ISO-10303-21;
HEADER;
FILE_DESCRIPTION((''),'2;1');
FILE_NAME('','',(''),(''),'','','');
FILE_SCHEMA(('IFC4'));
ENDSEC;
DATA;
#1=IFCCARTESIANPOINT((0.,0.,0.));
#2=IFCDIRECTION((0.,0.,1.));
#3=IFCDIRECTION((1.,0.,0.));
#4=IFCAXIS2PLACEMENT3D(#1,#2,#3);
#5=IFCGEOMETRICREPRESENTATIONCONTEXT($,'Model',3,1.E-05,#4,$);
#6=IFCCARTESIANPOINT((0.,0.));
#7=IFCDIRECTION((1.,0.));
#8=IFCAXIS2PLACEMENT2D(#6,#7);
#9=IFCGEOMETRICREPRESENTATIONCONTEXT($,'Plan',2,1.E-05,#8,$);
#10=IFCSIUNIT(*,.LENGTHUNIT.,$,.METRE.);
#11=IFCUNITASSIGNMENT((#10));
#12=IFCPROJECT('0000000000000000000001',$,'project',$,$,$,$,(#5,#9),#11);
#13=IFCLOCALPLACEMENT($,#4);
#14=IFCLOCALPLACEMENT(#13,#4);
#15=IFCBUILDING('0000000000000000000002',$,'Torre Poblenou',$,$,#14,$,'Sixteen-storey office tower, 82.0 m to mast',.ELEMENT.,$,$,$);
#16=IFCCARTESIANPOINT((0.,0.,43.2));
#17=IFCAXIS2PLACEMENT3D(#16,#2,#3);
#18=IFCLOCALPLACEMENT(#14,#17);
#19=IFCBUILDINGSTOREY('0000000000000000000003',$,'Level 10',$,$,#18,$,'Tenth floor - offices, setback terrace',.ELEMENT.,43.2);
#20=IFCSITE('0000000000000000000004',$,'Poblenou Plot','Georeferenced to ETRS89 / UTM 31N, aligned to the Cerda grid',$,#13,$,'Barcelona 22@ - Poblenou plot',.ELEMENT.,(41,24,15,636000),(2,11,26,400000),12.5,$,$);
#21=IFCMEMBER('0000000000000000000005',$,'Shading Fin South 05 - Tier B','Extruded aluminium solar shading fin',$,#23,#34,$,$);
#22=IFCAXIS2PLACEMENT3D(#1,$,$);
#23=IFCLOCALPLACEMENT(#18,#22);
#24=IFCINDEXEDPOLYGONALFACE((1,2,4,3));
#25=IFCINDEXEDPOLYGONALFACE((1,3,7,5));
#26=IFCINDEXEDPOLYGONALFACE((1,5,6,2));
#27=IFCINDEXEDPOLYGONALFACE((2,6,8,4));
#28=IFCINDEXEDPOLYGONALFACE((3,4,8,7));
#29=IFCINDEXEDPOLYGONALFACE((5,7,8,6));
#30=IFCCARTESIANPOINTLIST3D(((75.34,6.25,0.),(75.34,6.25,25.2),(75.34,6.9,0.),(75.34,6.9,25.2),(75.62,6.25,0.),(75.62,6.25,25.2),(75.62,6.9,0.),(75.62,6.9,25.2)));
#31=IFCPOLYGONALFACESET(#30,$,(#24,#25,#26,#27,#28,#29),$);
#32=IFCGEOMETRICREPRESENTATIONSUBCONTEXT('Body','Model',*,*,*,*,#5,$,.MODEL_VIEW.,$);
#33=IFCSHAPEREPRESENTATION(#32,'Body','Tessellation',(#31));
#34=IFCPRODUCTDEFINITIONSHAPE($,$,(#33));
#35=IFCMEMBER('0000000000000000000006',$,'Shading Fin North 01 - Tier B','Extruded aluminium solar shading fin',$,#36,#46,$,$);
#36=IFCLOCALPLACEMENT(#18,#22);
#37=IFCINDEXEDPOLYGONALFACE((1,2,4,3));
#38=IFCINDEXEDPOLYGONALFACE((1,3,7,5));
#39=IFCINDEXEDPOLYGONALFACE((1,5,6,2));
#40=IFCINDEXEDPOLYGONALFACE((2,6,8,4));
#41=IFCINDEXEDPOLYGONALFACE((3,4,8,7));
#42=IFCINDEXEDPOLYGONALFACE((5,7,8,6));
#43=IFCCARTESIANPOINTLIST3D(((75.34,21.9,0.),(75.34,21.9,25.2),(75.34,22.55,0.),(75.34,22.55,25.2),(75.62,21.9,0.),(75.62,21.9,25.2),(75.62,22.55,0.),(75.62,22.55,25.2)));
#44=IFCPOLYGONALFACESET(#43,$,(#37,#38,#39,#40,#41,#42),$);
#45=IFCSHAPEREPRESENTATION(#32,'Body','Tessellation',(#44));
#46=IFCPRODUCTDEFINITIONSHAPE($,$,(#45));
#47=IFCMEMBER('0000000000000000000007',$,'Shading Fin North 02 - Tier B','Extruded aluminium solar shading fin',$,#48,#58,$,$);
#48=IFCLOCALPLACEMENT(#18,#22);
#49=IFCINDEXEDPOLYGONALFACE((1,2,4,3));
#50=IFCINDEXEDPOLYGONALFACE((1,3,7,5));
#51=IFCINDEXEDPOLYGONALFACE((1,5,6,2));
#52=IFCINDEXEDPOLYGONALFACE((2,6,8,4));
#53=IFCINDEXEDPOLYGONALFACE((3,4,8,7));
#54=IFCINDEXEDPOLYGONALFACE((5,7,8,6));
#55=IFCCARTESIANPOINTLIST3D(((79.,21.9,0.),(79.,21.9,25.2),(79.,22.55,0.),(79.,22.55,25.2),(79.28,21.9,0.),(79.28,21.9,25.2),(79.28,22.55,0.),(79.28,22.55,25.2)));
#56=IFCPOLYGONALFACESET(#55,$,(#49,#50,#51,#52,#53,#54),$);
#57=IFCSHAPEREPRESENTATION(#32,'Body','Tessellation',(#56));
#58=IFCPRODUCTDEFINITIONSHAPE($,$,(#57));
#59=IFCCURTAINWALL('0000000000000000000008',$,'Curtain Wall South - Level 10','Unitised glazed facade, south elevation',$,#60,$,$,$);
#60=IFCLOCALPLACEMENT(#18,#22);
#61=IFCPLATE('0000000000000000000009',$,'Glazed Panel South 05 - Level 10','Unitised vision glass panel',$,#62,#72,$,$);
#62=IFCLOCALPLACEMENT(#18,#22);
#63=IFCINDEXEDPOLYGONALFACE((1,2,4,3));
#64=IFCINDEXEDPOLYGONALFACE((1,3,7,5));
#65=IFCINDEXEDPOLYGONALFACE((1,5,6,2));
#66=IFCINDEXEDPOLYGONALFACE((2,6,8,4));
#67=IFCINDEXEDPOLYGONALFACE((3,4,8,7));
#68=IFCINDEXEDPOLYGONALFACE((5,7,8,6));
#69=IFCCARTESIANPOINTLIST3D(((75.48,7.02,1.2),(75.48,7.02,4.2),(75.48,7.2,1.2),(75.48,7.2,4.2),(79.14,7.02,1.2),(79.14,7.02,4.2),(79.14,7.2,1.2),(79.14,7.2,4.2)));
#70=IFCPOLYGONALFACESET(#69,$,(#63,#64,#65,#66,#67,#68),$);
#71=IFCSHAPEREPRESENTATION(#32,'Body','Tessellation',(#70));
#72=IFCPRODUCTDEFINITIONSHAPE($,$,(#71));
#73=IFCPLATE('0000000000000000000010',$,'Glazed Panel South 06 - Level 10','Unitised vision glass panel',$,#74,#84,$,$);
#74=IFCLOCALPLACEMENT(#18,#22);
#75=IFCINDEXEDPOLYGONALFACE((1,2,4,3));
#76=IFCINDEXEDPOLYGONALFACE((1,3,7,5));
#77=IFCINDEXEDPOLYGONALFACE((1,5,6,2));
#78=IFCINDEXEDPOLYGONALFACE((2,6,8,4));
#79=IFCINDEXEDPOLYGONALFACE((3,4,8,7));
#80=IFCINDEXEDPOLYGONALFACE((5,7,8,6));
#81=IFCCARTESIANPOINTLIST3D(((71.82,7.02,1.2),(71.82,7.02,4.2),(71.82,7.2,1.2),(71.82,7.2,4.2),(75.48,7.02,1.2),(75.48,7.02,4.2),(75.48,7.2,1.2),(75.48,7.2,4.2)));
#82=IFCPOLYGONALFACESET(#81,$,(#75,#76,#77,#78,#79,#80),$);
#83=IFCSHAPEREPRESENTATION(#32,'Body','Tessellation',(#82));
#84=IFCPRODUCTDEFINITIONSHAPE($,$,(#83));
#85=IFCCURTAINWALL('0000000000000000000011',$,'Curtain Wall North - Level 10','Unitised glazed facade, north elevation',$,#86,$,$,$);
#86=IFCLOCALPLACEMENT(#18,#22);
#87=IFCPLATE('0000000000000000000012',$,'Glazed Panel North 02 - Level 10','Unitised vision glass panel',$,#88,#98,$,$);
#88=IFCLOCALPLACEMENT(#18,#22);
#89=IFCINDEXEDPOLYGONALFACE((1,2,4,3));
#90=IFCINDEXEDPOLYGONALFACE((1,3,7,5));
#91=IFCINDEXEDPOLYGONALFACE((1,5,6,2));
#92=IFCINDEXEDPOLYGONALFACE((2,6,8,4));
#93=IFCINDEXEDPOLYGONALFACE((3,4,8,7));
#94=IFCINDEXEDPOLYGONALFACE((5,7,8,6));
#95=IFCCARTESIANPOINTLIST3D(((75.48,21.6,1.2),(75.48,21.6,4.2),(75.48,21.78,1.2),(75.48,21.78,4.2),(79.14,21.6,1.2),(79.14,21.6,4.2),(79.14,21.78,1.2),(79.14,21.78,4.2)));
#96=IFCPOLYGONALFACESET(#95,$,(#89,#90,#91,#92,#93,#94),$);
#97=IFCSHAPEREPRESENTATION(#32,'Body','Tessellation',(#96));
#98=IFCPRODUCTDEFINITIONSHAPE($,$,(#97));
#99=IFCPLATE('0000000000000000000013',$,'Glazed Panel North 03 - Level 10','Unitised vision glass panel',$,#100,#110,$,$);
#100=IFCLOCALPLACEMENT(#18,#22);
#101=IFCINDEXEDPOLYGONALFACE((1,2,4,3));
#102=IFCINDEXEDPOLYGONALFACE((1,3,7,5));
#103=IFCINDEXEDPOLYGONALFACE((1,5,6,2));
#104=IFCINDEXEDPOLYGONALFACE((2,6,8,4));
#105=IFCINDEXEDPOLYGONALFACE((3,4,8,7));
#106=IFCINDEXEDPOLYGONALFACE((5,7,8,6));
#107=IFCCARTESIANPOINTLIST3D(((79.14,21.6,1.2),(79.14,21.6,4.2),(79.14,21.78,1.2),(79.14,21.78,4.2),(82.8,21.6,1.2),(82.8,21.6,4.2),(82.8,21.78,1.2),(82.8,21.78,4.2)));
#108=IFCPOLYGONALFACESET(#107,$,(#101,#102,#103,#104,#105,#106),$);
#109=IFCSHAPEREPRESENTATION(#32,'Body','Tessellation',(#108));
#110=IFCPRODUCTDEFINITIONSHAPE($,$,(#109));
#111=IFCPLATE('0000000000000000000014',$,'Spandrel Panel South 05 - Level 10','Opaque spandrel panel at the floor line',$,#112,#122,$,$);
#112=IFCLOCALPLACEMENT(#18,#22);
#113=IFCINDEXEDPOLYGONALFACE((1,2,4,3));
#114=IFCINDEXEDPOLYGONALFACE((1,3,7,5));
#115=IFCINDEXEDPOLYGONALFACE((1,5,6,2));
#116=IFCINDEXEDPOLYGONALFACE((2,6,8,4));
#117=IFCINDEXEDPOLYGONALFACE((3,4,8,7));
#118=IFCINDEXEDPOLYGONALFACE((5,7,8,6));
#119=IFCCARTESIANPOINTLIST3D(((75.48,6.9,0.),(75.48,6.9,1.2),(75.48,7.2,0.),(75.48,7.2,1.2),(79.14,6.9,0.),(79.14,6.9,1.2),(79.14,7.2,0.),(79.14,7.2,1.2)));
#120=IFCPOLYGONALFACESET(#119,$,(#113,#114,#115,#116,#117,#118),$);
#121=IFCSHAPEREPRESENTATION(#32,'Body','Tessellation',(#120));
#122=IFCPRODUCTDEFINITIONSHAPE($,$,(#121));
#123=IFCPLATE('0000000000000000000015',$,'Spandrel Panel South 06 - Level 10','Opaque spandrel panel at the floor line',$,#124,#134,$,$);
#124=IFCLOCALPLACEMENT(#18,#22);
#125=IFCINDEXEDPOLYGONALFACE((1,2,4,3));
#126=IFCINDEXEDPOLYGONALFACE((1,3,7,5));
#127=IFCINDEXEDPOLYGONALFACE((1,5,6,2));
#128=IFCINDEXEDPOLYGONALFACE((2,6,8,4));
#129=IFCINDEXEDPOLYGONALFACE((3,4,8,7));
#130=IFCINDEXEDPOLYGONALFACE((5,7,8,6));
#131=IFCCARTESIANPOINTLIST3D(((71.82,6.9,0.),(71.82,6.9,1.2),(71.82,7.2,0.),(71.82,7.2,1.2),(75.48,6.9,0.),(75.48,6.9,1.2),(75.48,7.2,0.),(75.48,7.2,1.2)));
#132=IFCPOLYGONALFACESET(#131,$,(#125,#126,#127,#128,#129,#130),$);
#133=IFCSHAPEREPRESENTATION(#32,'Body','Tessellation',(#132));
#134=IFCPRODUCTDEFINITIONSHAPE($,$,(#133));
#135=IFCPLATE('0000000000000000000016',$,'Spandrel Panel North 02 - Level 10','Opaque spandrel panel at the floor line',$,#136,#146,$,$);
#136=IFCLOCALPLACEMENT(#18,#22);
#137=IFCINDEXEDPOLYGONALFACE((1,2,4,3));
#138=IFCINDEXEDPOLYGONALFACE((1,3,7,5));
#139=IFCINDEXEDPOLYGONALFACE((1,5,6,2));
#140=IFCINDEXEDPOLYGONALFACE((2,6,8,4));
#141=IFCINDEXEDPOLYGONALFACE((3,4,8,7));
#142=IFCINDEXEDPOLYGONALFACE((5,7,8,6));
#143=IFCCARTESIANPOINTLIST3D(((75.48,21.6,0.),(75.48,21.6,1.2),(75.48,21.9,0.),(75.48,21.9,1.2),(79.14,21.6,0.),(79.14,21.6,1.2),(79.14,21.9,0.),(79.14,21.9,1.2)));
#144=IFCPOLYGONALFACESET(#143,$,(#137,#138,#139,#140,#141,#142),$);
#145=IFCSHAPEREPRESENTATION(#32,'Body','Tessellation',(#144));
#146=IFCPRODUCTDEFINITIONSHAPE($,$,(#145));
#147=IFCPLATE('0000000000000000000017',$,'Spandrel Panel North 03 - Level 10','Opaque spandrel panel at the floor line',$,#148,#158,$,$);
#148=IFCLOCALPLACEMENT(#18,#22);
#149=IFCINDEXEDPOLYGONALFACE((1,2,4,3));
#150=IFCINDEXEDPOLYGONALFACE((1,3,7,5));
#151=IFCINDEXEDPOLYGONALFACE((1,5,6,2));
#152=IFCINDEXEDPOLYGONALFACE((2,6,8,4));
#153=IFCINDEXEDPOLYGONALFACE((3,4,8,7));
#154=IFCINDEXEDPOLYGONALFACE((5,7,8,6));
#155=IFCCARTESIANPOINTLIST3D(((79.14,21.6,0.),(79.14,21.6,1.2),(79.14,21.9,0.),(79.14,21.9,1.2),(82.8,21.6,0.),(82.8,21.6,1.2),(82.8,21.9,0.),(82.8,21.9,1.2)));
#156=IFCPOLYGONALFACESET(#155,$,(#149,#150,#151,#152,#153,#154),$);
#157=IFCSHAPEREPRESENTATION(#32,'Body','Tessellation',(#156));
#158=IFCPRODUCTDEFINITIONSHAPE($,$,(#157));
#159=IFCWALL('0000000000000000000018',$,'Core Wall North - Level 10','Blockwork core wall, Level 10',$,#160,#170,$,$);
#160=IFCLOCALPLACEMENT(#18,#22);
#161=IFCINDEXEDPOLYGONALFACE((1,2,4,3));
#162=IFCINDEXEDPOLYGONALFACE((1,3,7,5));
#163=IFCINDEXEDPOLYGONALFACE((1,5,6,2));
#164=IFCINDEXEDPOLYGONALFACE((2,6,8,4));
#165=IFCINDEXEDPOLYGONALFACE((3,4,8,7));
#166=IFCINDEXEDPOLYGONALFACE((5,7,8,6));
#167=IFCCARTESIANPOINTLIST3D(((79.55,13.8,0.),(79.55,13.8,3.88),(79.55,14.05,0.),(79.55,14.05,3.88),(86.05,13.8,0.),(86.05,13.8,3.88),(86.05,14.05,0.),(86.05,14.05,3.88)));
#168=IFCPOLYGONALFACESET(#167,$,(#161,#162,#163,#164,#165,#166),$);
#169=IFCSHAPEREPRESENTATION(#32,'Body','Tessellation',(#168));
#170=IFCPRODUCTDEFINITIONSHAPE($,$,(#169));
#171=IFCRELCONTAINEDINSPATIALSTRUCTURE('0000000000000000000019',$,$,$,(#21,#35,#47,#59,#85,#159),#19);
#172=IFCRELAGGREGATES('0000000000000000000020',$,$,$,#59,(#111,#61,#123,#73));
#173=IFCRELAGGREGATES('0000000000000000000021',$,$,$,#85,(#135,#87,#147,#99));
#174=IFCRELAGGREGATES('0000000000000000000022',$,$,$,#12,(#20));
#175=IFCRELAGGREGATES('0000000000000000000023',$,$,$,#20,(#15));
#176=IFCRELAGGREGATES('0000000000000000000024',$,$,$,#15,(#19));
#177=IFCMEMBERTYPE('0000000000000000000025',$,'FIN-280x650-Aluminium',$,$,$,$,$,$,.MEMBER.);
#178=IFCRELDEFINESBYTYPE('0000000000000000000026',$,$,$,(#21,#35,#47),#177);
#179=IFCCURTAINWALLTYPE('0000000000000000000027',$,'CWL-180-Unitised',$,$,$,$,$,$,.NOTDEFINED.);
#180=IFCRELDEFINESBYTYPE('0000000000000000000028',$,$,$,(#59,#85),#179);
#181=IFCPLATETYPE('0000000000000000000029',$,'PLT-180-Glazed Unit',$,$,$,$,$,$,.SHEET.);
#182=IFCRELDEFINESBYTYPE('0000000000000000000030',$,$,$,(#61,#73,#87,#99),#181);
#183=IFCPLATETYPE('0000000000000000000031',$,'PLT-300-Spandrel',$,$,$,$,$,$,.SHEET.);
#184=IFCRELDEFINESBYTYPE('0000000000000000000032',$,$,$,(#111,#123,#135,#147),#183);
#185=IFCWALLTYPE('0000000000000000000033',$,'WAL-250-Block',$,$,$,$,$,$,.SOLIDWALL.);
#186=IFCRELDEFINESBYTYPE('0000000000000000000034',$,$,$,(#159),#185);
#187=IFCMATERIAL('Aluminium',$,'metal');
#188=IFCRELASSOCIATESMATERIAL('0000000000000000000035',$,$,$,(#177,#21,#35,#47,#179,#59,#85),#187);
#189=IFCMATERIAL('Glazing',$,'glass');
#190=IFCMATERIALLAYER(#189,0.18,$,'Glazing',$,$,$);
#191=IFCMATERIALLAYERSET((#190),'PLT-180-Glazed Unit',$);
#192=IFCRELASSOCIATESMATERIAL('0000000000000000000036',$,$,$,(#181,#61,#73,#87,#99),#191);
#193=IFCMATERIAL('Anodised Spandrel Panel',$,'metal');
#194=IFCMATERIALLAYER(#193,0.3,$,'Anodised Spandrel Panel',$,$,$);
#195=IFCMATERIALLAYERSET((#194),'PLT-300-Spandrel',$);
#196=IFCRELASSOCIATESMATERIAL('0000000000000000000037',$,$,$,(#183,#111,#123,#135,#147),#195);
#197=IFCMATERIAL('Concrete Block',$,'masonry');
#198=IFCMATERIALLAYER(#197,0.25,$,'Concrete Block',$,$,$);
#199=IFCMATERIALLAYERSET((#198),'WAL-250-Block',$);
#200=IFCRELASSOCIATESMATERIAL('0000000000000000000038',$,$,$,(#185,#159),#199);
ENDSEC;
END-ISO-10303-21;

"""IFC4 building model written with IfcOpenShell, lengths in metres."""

from ifc_helpers import new_model, si_unit, frame, origin_with_axes, origin_2d_with_axis, place, context, subcontext, project, spatial, line, indexed_curve, rectangle, outline, extrude, material, layer, layer_set, layer_usage, material_profile, profile_set, profile_usage, type_object, element, aggregate, save


model = new_model("IFC4")

# Units and contexts
model_context = context("Model", 3, precision=1e-05, world=origin_with_axes())
plan_context = context("Plan", 2, precision=1e-05, world=origin_2d_with_axis())
body_context = subcontext(model_context, "Body", "Model", "MODEL_VIEW")
ifc_project = project(units=[si_unit("LENGTHUNIT", "METRE")], contexts=[model_context, plan_context])

# Site, building, storey
site_placement = place(None, origin_with_axes())
site = spatial("IfcSite", under=ifc_project, at=site_placement, Name="Poblenou Plot", Description="Georeferenced to ETRS89 / UTM 31N, aligned to the Cerda grid", LongName="Barcelona 22@ - Poblenou plot", CompositionType="ELEMENT", RefLatitude=(41, 24, 15, 636000), RefLongitude=(2, 11, 26, 400000), RefElevation=12.5)
building_placement = place(site_placement, origin_with_axes())
building = spatial("IfcBuilding", under=site, at=building_placement, Name="Torre Poblenou", LongName="Sixteen-storey office tower, 82.0 m to mast", CompositionType="ELEMENT")
storey_placement = place(building_placement, frame((0.0, 0.0, 43.2), z_axis=(0.0, 0.0, 1.0), x_axis=(1.0, 0.0, 0.0)))
storey = spatial("IfcBuildingStorey", under=building, at=storey_placement, Name="Level 10", LongName="Tenth floor - offices, setback terrace", CompositionType="ELEMENT", Elevation=43.2)

# Members
ifc_material_1 = material(Name="Aluminium", Category="metal")
ifc_material_profile_1 = material_profile(ifc_material_1, rectangle(XDim=0.28, YDim=0.65))
ifc_profile_set_1 = profile_set([ifc_material_profile_1], Name="FIN-280x650-Aluminium")
member_type = type_object("IfcMemberType", Name="FIN-280x650-Aluminium", PredefinedType="MEMBER", material=ifc_profile_set_1)
ifc_profile_usage_1 = profile_usage(ifc_profile_set_1)
member_1_placement = place(storey_placement, frame((75.62, 6.9, 0.0), z_axis=(0.0, 0.0, 1.0), x_axis=(-1.0, 0.0, 0.0)))
element("IfcMember", 1, at=member_1_placement, inside=storey, type_object=member_type, material=ifc_profile_usage_1, Name="Shading Fin South 05 - Tier B", Description="Extruded aluminium solar shading fin", context=body_context, shape_type="SweptSolid", body=[
    extrude(outline(indexed_curve([(0.0, 0.0), (0.28, 0.0), (0.28, 0.65), (0.0, 0.65)], segments=[line(1, 2, 3, 4, 1)])), origin_with_axes(), (0.0, 0.0, 1.0), 25.2),
])
ifc_profile_usage_2 = profile_usage(ifc_profile_set_1)
member_2_placement = place(storey_placement, frame((75.34, 21.9, 0.0), z_axis=(0.0, 0.0, 1.0), x_axis=(1.0, 0.0, 0.0)))
element("IfcMember", 2, at=member_2_placement, inside=storey, type_object=member_type, material=ifc_profile_usage_2, Name="Shading Fin North 01 - Tier B", Description="Extruded aluminium solar shading fin", context=body_context, shape_type="SweptSolid", body=[
    extrude(outline(indexed_curve([(0.0, 0.0), (0.28, 0.0), (0.28, 0.65), (0.0, 0.65)], segments=[line(1, 2, 3, 4, 1)])), origin_with_axes(), (0.0, 0.0, 1.0), 25.2),
])
ifc_profile_usage_3 = profile_usage(ifc_profile_set_1)
member_3_placement = place(storey_placement, frame((79.0, 21.9, 0.0), z_axis=(0.0, 0.0, 1.0), x_axis=(1.0, 0.0, 0.0)))
element("IfcMember", 3, at=member_3_placement, inside=storey, type_object=member_type, material=ifc_profile_usage_3, Name="Shading Fin North 02 - Tier B", Description="Extruded aluminium solar shading fin", context=body_context, shape_type="SweptSolid", body=[
    extrude(outline(indexed_curve([(0.0, 0.0), (0.28, 0.0), (0.28, 0.65), (0.0, 0.65)], segments=[line(1, 2, 3, 4, 1)])), origin_with_axes(), (0.0, 0.0, 1.0), 25.2),
])

# Curtain walls, plates
curtain_wall_type = type_object("IfcCurtainWallType", Name="CWL-180-Unitised", PredefinedType="NOTDEFINED", material=ifc_material_1)
curtain_wall_1_placement = place(storey_placement, frame((93.78, 7.2, 0.0), z_axis=(0.0, 0.0, 1.0), x_axis=(-1.0, 0.0, 0.0)))
curtain_wall_1 = element("IfcCurtainWall", 4, at=curtain_wall_1_placement, inside=storey, type_object=curtain_wall_type, material=ifc_material_1, Name="Curtain Wall South - Level 10", Description="Unitised glazed facade, south elevation")
ifc_material_2 = material(Name="Glazing", Category="glass")
ifc_layer_1 = layer(ifc_material_2, 0.18, Name="Glazing")
ifc_layer_set_1 = layer_set([ifc_layer_1], Name="PLT-180-Glazed Unit")
ifc_layer_usage_1 = layer_usage(ifc_layer_set_1, "AXIS2", "POSITIVE", 0.0)
plate_type_1 = type_object("IfcPlateType", Name="PLT-180-Glazed Unit", PredefinedType="SHEET", material=ifc_layer_set_1)
plate_1_placement = place(curtain_wall_1_placement, frame((14.64, 0.0, 1.2), z_axis=(0.0, 0.0, 1.0), x_axis=(1.0, 0.0, 0.0)))
plate_1 = element("IfcPlate", 5, at=plate_1_placement, type_object=plate_type_1, material=ifc_layer_usage_1, Name="Glazed Panel South 05 - Level 10", Description="Unitised vision glass panel", context=body_context, shape_type="SweptSolid", body=[
    extrude(outline(indexed_curve([(0.0, 0.0), (3.66, 0.0), (3.66, 0.18), (0.0, 0.18)], segments=[line(1, 2, 3, 4, 1)])), origin_with_axes(), (0.0, 0.0, 1.0), 3.0),
])
ifc_layer_usage_2 = layer_usage(ifc_layer_set_1, "AXIS2", "POSITIVE", 0.0)
plate_2_placement = place(curtain_wall_1_placement, frame((18.3, 0.0, 1.2), z_axis=(0.0, 0.0, 1.0), x_axis=(1.0, 0.0, 0.0)))
plate_2 = element("IfcPlate", 6, at=plate_2_placement, type_object=plate_type_1, material=ifc_layer_usage_2, Name="Glazed Panel South 06 - Level 10", Description="Unitised vision glass panel", context=body_context, shape_type="SweptSolid", body=[
    extrude(outline(indexed_curve([(0.0, 0.0), (3.66, 0.0), (3.66, 0.18), (0.0, 0.18)], segments=[line(1, 2, 3, 4, 1)])), origin_with_axes(), (0.0, 0.0, 1.0), 3.0),
])
curtain_wall_2_placement = place(storey_placement, frame((71.82, 21.6, 0.0), z_axis=(0.0, 0.0, 1.0), x_axis=(1.0, 0.0, 0.0)))
curtain_wall_2 = element("IfcCurtainWall", 7, at=curtain_wall_2_placement, inside=storey, type_object=curtain_wall_type, material=ifc_material_1, Name="Curtain Wall North - Level 10", Description="Unitised glazed facade, north elevation")
ifc_layer_usage_3 = layer_usage(ifc_layer_set_1, "AXIS2", "POSITIVE", 0.0)
plate_3_placement = place(curtain_wall_2_placement, frame((3.66, 0.0, 1.2), z_axis=(0.0, 0.0, 1.0), x_axis=(1.0, 0.0, 0.0)))
plate_3 = element("IfcPlate", 8, at=plate_3_placement, type_object=plate_type_1, material=ifc_layer_usage_3, Name="Glazed Panel North 02 - Level 10", Description="Unitised vision glass panel", context=body_context, shape_type="SweptSolid", body=[
    extrude(outline(indexed_curve([(0.0, 0.0), (3.66, 0.0), (3.66, 0.18), (0.0, 0.18)], segments=[line(1, 2, 3, 4, 1)])), origin_with_axes(), (0.0, 0.0, 1.0), 3.0),
])
ifc_layer_usage_4 = layer_usage(ifc_layer_set_1, "AXIS2", "POSITIVE", 0.0)
plate_4_placement = place(curtain_wall_2_placement, frame((7.32, 0.0, 1.2), z_axis=(0.0, 0.0, 1.0), x_axis=(1.0, 0.0, 0.0)))
plate_4 = element("IfcPlate", 9, at=plate_4_placement, type_object=plate_type_1, material=ifc_layer_usage_4, Name="Glazed Panel North 03 - Level 10", Description="Unitised vision glass panel", context=body_context, shape_type="SweptSolid", body=[
    extrude(outline(indexed_curve([(0.0, 0.0), (3.66, 0.0), (3.66, 0.18), (0.0, 0.18)], segments=[line(1, 2, 3, 4, 1)])), origin_with_axes(), (0.0, 0.0, 1.0), 3.0),
])

# Plates
ifc_material_3 = material(Name="Anodised Spandrel Panel", Category="metal")
ifc_layer_2 = layer(ifc_material_3, 0.3, Name="Anodised Spandrel Panel")
ifc_layer_set_2 = layer_set([ifc_layer_2], Name="PLT-300-Spandrel")
ifc_layer_usage_5 = layer_usage(ifc_layer_set_2, "AXIS2", "POSITIVE", 0.0)
plate_type_2 = type_object("IfcPlateType", Name="PLT-300-Spandrel", PredefinedType="SHEET", material=ifc_layer_set_2)
plate_5_placement = place(curtain_wall_1_placement, frame((14.64, 0.0, 0.0), z_axis=(0.0, 0.0, 1.0), x_axis=(1.0, 0.0, 0.0)))
plate_5 = element("IfcPlate", 10, at=plate_5_placement, type_object=plate_type_2, material=ifc_layer_usage_5, Name="Spandrel Panel South 05 - Level 10", Description="Opaque spandrel panel at the floor line", context=body_context, shape_type="SweptSolid", body=[
    extrude(outline(indexed_curve([(0.0, 0.0), (3.66, 0.0), (3.66, 0.3), (0.0, 0.3)], segments=[line(1, 2, 3, 4, 1)])), origin_with_axes(), (0.0, 0.0, 1.0), 1.2),
])
ifc_layer_usage_6 = layer_usage(ifc_layer_set_2, "AXIS2", "POSITIVE", 0.0)
plate_6_placement = place(curtain_wall_1_placement, frame((18.3, 0.0, 0.0), z_axis=(0.0, 0.0, 1.0), x_axis=(1.0, 0.0, 0.0)))
plate_6 = element("IfcPlate", 11, at=plate_6_placement, type_object=plate_type_2, material=ifc_layer_usage_6, Name="Spandrel Panel South 06 - Level 10", Description="Opaque spandrel panel at the floor line", context=body_context, shape_type="SweptSolid", body=[
    extrude(outline(indexed_curve([(0.0, 0.0), (3.66, 0.0), (3.66, 0.3), (0.0, 0.3)], segments=[line(1, 2, 3, 4, 1)])), origin_with_axes(), (0.0, 0.0, 1.0), 1.2),
])
aggregate(curtain_wall_1, [plate_5, plate_1, plate_6, plate_2])
ifc_layer_usage_7 = layer_usage(ifc_layer_set_2, "AXIS2", "POSITIVE", 0.0)
plate_7_placement = place(curtain_wall_2_placement, frame((3.66, 0.0, 0.0), z_axis=(0.0, 0.0, 1.0), x_axis=(1.0, 0.0, 0.0)))
plate_7 = element("IfcPlate", 12, at=plate_7_placement, type_object=plate_type_2, material=ifc_layer_usage_7, Name="Spandrel Panel North 02 - Level 10", Description="Opaque spandrel panel at the floor line", context=body_context, shape_type="SweptSolid", body=[
    extrude(outline(indexed_curve([(0.0, 0.0), (3.66, 0.0), (3.66, 0.3), (0.0, 0.3)], segments=[line(1, 2, 3, 4, 1)])), origin_with_axes(), (0.0, 0.0, 1.0), 1.2),
])
ifc_layer_usage_8 = layer_usage(ifc_layer_set_2, "AXIS2", "POSITIVE", 0.0)
plate_8_placement = place(curtain_wall_2_placement, frame((7.32, 0.0, 0.0), z_axis=(0.0, 0.0, 1.0), x_axis=(1.0, 0.0, 0.0)))
plate_8 = element("IfcPlate", 13, at=plate_8_placement, type_object=plate_type_2, material=ifc_layer_usage_8, Name="Spandrel Panel North 03 - Level 10", Description="Opaque spandrel panel at the floor line", context=body_context, shape_type="SweptSolid", body=[
    extrude(outline(indexed_curve([(0.0, 0.0), (3.66, 0.0), (3.66, 0.3), (0.0, 0.3)], segments=[line(1, 2, 3, 4, 1)])), origin_with_axes(), (0.0, 0.0, 1.0), 1.2),
])
aggregate(curtain_wall_2, [plate_7, plate_3, plate_8, plate_4])

# Wall
ifc_material_4 = material(Name="Concrete Block", Category="masonry")
ifc_layer_3 = layer(ifc_material_4, 0.25, Name="Concrete Block")
ifc_layer_set_3 = layer_set([ifc_layer_3], Name="WAL-250-Block")
ifc_layer_usage_9 = layer_usage(ifc_layer_set_3, "AXIS2", "POSITIVE", 0.0)
wall_type = type_object("IfcWallType", Name="WAL-250-Block", PredefinedType="SOLIDWALL", material=ifc_layer_set_3)
wall_1_placement = place(storey_placement, frame((79.55, 13.8, 0.0), z_axis=(0.0, 0.0, 1.0), x_axis=(1.0, 0.0, 0.0)))
element("IfcWall", 14, at=wall_1_placement, inside=storey, type_object=wall_type, material=ifc_layer_usage_9, Name="Core Wall North - Level 10", Description="Blockwork core wall, Level 10", context=body_context, shape_type="SweptSolid", body=[
    extrude(outline(indexed_curve([(0.0, 0.0), (6.5, 0.0), (6.5, 0.25), (0.0, 0.25)], segments=[line(1, 2, 3, 4, 1)])), origin_with_axes(), (0.0, 0.0, 1.0), 3.88),
])

save(model, "model.ifc")
